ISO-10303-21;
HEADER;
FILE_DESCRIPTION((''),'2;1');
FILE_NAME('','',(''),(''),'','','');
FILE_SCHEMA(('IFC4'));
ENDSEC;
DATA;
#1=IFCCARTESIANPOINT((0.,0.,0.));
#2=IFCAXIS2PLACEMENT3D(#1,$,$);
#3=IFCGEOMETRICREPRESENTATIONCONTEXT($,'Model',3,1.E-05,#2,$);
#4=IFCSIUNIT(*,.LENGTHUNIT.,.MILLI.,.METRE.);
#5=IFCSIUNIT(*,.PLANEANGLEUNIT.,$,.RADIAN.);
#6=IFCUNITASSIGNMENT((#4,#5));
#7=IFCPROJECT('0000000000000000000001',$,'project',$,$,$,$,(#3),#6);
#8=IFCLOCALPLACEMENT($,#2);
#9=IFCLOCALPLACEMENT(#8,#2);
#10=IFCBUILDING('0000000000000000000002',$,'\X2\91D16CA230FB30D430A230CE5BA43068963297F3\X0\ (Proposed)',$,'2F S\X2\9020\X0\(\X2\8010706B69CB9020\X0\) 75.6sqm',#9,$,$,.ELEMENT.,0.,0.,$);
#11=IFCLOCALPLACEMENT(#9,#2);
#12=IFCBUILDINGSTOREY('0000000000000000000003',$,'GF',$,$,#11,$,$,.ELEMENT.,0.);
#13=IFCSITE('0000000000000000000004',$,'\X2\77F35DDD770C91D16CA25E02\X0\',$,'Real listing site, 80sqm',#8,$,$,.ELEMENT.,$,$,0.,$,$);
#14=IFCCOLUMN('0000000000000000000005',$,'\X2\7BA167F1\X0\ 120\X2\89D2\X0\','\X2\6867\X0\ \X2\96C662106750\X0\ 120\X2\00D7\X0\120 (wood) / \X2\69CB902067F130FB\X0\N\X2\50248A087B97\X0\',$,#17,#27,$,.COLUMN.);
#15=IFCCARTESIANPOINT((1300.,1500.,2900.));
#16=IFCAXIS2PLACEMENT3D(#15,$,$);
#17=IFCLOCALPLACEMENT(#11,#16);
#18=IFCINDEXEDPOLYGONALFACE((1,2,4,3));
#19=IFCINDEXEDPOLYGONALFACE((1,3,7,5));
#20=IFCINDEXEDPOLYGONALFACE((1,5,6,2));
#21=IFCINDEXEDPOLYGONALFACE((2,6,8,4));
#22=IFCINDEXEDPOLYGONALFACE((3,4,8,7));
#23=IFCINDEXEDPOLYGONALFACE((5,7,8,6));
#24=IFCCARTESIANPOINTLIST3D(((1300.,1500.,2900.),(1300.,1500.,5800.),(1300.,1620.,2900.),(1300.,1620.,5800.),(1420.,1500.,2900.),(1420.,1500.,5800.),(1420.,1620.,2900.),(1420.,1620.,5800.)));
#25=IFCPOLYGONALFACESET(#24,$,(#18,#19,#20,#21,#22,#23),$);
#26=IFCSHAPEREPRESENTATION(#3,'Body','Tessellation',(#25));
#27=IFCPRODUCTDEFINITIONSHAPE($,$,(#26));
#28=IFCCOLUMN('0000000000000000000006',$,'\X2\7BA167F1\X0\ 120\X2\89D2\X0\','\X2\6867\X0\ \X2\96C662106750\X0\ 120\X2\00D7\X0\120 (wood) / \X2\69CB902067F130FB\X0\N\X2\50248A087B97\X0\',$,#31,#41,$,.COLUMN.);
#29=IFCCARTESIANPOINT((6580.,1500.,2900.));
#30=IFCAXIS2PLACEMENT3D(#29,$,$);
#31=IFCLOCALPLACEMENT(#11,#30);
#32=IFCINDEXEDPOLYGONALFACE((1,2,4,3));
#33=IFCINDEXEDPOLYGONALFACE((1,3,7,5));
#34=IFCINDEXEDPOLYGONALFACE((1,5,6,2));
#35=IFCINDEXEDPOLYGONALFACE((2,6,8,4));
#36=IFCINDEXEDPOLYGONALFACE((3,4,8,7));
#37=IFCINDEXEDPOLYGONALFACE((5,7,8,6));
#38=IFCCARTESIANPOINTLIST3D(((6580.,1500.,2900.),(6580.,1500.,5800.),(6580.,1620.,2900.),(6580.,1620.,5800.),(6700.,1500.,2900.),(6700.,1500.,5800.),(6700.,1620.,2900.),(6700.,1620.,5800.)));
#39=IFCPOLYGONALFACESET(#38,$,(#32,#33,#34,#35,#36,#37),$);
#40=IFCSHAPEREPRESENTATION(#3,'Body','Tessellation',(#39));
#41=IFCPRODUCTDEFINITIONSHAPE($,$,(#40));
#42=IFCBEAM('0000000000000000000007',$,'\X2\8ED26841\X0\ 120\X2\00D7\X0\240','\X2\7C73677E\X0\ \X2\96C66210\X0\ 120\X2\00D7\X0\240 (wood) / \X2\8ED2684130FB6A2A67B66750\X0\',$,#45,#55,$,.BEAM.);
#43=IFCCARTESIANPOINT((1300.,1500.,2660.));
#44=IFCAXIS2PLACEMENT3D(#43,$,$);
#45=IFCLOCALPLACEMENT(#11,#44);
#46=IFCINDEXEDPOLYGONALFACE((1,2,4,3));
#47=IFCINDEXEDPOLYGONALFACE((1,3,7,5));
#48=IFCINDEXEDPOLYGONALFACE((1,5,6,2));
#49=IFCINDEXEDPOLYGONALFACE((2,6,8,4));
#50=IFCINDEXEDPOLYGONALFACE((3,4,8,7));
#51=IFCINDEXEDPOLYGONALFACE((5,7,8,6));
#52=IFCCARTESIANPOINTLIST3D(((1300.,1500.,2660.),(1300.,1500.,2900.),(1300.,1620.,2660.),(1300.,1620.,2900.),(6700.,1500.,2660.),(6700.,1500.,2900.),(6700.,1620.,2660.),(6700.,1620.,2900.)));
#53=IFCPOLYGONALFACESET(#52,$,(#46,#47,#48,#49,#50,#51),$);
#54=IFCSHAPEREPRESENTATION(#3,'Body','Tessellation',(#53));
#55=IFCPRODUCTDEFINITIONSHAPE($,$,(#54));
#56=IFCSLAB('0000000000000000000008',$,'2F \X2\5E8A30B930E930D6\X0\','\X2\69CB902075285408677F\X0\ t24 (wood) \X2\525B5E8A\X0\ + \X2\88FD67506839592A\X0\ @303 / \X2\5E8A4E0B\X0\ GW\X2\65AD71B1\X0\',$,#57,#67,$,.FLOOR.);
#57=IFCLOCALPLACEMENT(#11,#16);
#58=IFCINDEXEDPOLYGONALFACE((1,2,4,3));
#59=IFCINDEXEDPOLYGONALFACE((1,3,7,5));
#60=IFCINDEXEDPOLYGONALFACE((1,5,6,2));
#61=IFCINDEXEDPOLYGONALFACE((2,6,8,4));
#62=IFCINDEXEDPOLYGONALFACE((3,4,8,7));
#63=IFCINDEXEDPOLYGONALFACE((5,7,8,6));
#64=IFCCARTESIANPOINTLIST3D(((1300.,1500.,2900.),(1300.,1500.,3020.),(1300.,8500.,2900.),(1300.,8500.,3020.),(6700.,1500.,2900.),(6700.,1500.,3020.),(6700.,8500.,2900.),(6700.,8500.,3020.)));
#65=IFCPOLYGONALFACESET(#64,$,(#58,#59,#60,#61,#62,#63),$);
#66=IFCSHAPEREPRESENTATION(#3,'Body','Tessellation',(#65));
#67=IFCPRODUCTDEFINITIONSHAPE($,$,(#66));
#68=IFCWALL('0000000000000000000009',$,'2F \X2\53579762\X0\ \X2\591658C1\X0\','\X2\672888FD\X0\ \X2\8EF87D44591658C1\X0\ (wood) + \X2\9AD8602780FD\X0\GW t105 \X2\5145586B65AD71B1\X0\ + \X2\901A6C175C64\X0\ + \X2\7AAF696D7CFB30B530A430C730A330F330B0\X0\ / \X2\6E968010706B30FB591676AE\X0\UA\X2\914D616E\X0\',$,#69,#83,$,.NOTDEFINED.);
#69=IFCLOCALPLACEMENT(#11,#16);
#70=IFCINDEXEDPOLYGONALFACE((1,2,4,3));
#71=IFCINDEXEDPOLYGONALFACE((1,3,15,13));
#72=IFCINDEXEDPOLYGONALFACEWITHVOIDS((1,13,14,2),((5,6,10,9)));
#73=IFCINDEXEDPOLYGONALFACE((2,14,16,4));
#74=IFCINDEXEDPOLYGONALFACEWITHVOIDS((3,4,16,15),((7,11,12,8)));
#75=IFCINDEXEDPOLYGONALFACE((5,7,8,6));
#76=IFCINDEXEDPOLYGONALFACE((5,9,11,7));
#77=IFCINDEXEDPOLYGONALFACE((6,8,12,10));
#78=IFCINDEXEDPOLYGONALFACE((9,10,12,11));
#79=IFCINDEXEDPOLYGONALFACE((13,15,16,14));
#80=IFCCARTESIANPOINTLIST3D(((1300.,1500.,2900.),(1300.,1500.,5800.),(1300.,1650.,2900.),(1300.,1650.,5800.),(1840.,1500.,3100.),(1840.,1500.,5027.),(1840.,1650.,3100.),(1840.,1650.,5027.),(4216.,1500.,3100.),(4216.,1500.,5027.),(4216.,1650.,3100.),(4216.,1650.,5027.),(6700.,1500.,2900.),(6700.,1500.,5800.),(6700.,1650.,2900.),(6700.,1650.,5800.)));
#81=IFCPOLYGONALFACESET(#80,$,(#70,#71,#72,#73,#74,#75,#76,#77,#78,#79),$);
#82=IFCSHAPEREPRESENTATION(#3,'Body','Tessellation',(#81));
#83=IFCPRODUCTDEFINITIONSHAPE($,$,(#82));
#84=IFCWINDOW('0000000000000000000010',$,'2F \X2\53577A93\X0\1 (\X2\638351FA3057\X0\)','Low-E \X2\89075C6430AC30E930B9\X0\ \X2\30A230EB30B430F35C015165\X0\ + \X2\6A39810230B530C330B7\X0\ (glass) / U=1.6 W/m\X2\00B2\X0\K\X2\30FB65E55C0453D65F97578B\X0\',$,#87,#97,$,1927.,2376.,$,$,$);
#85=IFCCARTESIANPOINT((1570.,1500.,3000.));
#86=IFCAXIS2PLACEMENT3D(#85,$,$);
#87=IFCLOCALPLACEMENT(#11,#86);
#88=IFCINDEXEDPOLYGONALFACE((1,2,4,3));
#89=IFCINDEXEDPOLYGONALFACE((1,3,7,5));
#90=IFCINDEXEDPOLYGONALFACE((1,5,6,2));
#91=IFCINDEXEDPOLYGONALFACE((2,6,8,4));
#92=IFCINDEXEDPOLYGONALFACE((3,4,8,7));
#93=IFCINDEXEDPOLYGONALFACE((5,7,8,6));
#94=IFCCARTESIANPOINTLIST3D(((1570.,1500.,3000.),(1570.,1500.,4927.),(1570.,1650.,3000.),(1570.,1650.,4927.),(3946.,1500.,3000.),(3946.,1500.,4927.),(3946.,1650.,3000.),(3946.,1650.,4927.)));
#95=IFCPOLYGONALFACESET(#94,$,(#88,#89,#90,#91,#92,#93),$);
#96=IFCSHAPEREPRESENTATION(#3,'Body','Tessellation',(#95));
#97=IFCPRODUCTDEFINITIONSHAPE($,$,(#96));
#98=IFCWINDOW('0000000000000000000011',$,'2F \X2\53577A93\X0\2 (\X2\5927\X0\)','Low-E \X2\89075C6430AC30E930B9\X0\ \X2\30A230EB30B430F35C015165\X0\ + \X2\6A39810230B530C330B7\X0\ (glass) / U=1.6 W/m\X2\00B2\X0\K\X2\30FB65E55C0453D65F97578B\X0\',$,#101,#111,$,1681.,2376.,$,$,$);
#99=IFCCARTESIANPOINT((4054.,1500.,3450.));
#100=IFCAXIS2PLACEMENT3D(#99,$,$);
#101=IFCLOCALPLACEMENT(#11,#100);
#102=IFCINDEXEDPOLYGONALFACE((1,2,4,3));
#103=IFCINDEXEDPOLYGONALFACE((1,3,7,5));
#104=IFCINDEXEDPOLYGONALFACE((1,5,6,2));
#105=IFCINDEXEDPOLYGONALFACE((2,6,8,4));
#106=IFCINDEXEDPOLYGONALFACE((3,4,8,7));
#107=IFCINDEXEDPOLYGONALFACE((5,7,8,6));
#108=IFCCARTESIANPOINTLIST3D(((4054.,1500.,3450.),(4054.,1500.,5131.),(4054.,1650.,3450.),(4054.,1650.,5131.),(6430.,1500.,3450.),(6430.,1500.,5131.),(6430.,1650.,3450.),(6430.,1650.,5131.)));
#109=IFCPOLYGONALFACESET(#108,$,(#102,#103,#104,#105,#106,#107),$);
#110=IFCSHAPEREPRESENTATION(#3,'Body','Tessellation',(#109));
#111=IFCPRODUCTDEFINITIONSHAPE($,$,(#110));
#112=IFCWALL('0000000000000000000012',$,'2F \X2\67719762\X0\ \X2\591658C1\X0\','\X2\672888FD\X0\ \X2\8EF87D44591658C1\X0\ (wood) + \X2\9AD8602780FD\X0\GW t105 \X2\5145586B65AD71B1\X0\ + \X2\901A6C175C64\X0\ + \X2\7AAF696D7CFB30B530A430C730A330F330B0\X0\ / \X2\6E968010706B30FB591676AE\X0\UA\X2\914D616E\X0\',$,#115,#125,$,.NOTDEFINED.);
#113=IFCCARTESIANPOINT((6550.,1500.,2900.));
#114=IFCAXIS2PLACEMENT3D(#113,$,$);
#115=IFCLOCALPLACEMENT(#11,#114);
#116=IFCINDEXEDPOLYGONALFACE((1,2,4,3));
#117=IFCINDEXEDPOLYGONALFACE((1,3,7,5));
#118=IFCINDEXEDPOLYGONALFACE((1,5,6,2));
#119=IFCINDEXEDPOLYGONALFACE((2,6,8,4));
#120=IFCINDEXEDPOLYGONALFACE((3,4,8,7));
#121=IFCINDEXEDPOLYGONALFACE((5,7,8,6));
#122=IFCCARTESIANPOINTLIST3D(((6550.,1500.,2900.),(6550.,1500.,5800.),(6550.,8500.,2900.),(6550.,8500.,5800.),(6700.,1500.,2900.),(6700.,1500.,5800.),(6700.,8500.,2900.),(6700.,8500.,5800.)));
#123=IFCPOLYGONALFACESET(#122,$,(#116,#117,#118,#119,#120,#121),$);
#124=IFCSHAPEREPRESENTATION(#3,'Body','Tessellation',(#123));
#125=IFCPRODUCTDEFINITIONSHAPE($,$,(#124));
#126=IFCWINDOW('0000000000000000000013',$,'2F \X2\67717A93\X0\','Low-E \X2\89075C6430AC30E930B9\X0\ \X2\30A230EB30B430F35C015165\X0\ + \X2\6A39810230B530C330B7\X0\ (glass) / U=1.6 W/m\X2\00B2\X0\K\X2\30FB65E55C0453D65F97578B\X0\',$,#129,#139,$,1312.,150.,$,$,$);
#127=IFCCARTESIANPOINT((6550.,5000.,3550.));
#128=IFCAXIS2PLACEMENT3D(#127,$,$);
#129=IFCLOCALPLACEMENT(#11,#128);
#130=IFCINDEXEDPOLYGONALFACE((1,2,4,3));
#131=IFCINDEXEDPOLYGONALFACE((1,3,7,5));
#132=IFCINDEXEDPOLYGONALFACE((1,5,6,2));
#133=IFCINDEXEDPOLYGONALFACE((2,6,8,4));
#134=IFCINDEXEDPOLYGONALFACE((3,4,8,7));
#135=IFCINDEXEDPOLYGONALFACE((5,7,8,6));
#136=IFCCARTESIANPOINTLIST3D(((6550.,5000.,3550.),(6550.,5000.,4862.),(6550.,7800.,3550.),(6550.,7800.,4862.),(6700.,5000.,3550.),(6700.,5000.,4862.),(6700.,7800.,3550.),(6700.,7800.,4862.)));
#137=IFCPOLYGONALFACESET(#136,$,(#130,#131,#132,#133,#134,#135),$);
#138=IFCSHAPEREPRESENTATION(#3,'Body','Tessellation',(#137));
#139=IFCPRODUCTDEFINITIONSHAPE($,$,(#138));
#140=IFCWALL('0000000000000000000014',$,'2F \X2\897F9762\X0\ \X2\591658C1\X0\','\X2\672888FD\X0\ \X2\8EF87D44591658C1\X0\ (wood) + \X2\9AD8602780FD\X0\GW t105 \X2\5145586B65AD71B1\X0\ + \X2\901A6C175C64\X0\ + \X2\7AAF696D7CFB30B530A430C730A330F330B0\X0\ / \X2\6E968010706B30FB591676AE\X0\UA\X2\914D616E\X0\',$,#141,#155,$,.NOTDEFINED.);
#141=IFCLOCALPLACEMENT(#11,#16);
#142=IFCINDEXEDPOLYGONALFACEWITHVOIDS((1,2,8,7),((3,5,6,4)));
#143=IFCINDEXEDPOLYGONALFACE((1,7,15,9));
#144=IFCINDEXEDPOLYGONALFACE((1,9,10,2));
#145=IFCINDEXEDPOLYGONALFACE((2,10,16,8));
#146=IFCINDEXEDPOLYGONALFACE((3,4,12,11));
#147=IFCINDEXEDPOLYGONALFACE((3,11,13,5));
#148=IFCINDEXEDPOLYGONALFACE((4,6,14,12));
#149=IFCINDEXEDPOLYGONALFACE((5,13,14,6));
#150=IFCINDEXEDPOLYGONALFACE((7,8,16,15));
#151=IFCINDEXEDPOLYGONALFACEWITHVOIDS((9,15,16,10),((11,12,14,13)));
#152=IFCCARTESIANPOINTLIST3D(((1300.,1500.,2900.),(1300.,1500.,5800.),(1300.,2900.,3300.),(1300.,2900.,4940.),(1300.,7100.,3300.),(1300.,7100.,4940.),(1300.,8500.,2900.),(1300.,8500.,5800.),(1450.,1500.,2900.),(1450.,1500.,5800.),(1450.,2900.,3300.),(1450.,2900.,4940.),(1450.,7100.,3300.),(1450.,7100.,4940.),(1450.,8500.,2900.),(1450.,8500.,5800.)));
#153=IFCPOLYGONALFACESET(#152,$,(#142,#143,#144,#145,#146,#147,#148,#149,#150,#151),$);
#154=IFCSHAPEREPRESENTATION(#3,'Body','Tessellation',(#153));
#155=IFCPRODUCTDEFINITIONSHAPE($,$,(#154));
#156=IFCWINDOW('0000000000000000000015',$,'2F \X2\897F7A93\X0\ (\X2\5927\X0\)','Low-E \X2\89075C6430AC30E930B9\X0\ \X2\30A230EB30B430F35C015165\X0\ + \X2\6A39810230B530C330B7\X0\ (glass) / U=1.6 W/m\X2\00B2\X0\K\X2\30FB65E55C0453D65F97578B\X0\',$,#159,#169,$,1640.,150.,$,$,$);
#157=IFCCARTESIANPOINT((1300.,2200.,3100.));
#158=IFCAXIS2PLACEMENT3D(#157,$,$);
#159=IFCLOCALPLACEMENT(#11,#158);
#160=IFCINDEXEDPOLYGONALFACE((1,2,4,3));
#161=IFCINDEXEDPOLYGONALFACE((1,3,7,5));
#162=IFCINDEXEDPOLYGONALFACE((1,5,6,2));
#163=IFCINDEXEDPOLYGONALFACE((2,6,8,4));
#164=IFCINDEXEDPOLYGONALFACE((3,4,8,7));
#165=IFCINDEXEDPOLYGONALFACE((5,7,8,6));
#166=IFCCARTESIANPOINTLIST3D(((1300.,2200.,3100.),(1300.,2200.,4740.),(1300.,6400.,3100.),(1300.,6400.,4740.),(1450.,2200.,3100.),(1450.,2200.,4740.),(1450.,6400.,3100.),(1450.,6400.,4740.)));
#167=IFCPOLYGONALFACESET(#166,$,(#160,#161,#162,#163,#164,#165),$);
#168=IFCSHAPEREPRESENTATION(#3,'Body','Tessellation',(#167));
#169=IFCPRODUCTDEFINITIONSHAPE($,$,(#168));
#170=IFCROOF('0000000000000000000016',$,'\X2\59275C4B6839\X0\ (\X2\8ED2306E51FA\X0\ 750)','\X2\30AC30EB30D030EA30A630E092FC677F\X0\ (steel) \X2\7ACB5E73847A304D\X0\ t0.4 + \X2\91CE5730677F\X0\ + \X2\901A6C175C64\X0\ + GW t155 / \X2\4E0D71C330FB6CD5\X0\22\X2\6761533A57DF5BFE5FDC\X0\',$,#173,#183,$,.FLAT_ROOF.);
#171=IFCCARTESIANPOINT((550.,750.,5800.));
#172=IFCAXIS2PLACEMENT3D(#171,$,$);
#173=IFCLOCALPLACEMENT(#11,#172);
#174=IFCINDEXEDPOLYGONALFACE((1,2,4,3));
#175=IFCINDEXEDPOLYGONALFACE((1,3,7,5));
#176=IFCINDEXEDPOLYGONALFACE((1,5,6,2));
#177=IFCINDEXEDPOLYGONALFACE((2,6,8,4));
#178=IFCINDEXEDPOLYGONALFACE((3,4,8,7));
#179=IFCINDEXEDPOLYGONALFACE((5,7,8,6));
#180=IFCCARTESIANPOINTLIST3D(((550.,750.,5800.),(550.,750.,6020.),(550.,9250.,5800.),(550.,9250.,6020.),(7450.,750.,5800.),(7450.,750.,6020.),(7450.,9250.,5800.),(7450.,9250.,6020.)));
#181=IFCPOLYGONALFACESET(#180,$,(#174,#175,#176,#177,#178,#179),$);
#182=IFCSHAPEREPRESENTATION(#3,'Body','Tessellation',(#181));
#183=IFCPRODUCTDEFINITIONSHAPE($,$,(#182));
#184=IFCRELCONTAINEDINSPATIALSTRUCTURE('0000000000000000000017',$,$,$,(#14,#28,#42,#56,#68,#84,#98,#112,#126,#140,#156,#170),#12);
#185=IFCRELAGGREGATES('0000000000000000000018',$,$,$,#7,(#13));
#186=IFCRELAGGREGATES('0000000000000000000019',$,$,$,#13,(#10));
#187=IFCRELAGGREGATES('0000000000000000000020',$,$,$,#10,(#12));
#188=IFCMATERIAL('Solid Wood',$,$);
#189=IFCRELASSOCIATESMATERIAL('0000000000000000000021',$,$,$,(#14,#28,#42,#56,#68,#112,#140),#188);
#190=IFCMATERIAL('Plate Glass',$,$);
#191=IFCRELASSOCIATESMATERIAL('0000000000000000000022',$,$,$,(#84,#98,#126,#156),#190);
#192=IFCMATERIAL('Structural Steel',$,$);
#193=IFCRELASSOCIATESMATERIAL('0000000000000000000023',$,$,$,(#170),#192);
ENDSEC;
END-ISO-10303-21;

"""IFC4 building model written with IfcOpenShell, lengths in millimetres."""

from ifc_helpers import new_model, si_unit, frame, frame_2d, origin, place, context, project, spatial, rectangle, extrude, material, element, fill, save


model = new_model("IFC4")

# Units and contexts
model_context = context("Model", 3, precision=1e-05, world=origin())
ifc_project = project(units=[si_unit("LENGTHUNIT", "METRE", prefix="MILLI"), si_unit("PLANEANGLEUNIT", "RADIAN")], contexts=[model_context])

# Site, building, storey
site_placement = place(None, origin())
site = spatial("IfcSite", under=ifc_project, at=site_placement, Name="石川県金沢市", ObjectType="Real listing site, 80sqm", CompositionType="ELEMENT", RefElevation=0.0)
building_placement = place(site_placement, origin())
building = spatial("IfcBuilding", under=site, at=building_placement, Name="金沢・ピアノ室と防音 (Proposed)", ObjectType="2F S造(耐火構造) 75.6sqm", CompositionType="ELEMENT", ElevationOfRefHeight=0.0, ElevationOfTerrain=0.0)
storey_placement = place(building_placement, origin())
storey = spatial("IfcBuildingStorey", under=building, at=storey_placement, Name="GF", CompositionType="ELEMENT", Elevation=0.0)

# Columns
ifc_material_1 = material(Name="Solid Wood")
column_1_placement = place(storey_placement, frame((1300.0, 1500.0, 2900.0)))
element("IfcColumn", 1, at=column_1_placement, inside=storey, material=ifc_material_1, Name="管柱 120角", Description="桧 集成材 120×120 (wood) / 構造柱・N値計算", PredefinedType="COLUMN", context=model_context, shape_type="SweptSolid", body=[
    extrude(rectangle(XDim=120.0, YDim=120.0, at=frame_2d((60.0, 60.0))), frame((1300.0, 1500.0, 2900.0)), (0.0, 0.0, 1.0), 2900.0),
])
column_2_placement = place(storey_placement, frame((6580.0, 1500.0, 2900.0)))
element("IfcColumn", 2, at=column_2_placement, inside=storey, material=ifc_material_1, Name="管柱 120角", Description="桧 集成材 120×120 (wood) / 構造柱・N値計算", PredefinedType="COLUMN", context=model_context, shape_type="SweptSolid", body=[
    extrude(rectangle(XDim=120.0, YDim=120.0, at=frame_2d((60.0, 60.0))), frame((6580.0, 1500.0, 2900.0)), (0.0, 0.0, 1.0), 2900.0),
])

# Beam
beam_1_placement = place(storey_placement, frame((1300.0, 1500.0, 2660.0)))
element("IfcBeam", 3, at=beam_1_placement, inside=storey, material=ifc_material_1, Name="軒桁 120×240", Description="米松 集成 120×240 (wood) / 軒桁・横架材", PredefinedType="BEAM", context=model_context, shape_type="SweptSolid", body=[
    extrude(rectangle(XDim=5400.0, YDim=120.0, at=frame_2d((2700.0, 60.0))), frame((1300.0, 1500.0, 2660.0)), (0.0, 0.0, 1.0), 240.0),
])

# Slab
slab_placement = place(storey_placement, frame((1300.0, 1500.0, 2900.0)))
element("IfcSlab", 4, at=slab_placement, inside=storey, material=ifc_material_1, Name="2F 床スラブ", Description="構造用合板 t24 (wood) 剛床 + 製材根太 @303 / 床下 GW断熱", PredefinedType="FLOOR", context=model_context, shape_type="SweptSolid", body=[
    extrude(rectangle(XDim=5400.0, YDim=7000.0, at=frame_2d((2700.0, 3500.0))), frame((1300.0, 1500.0, 2900.0)), (0.0, 0.0, 1.0), 120.0),
])

# Wall, openings, windows
wall_1_placement = place(storey_placement, frame((1300.0, 1500.0, 2900.0)))
wall_1 = element("IfcWall", 5, at=wall_1_placement, inside=storey, material=ifc_material_1, Name="2F 南面 外壁", Description="木製 軸組外壁 (wood) + 高性能GW t105 充填断熱 + 通気層 + 窯業系サイディング / 準耐火・外皮UA配慮", PredefinedType="NOTDEFINED", context=model_context, shape_type="SweptSolid", body=[
    extrude(rectangle(XDim=5400.0, YDim=150.0, at=frame_2d((2700.0, 75.0))), frame((1300.0, 1500.0, 2900.0)), (0.0, 0.0, 1.0), 2900.0),
])
opening_1_placement = place(storey_placement, frame((1570.0, 1500.0, 3000.0)))
opening_1 = element("IfcOpeningElement", 6, at=opening_1_placement, cuts=wall_1, PredefinedType="NOTDEFINED", context=model_context, shape_type="SweptSolid", body=[
    extrude(rectangle(XDim=2376.0, YDim=150.0, at=frame_2d((1188.0, 75.0))), frame((1570.0, 1500.0, 3000.0)), (0.0, 0.0, 1.0), 1927.0),
])
opening_2_placement = place(storey_placement, frame((4054.0, 1500.0, 3450.0)))
opening_2 = element("IfcOpeningElement", 7, at=opening_2_placement, cuts=wall_1, PredefinedType="NOTDEFINED", context=model_context, shape_type="SweptSolid", body=[
    extrude(rectangle(XDim=2376.0, YDim=150.0, at=frame_2d((1188.0, 75.0))), frame((4054.0, 1500.0, 3450.0)), (0.0, 0.0, 1.0), 1681.0),
])
ifc_material_2 = material(Name="Plate Glass")
window_1_placement = place(storey_placement, frame((1570.0, 1500.0, 3000.0)))
window_1 = element("IfcWindow", 8, at=window_1_placement, inside=storey, material=ifc_material_2, Name="2F 南窓1 (掃出し)", Description="Low-E 複層ガラス アルゴン封入 + 樹脂サッシ (glass) / U=1.6 W/m²K・日射取得型", OverallHeight=1927.0, OverallWidth=2376.0, context=model_context, shape_type="SweptSolid", body=[
    extrude(rectangle(XDim=2376.0, YDim=150.0, at=frame_2d((1188.0, 75.0))), frame((1570.0, 1500.0, 3000.0)), (0.0, 0.0, 1.0), 1927.0),
])
fill(opening_1, window_1)
window_2_placement = place(storey_placement, frame((4054.0, 1500.0, 3450.0)))
window_2 = element("IfcWindow", 9, at=window_2_placement, inside=storey, material=ifc_material_2, Name="2F 南窓2 (大)", Description="Low-E 複層ガラス アルゴン封入 + 樹脂サッシ (glass) / U=1.6 W/m²K・日射取得型", OverallHeight=1681.0, OverallWidth=2376.0, context=model_context, shape_type="SweptSolid", body=[
    extrude(rectangle(XDim=2376.0, YDim=150.0, at=frame_2d((1188.0, 75.0))), frame((4054.0, 1500.0, 3450.0)), (0.0, 0.0, 1.0), 1681.0),
])
fill(opening_2, window_2)

# Walls, openings, windows
wall_2_placement = place(storey_placement, frame((6550.0, 1500.0, 2900.0)))
wall_2 = element("IfcWall", 10, at=wall_2_placement, inside=storey, material=ifc_material_1, Name="2F 東面 外壁", Description="木製 軸組外壁 (wood) + 高性能GW t105 充填断熱 + 通気層 + 窯業系サイディング / 準耐火・外皮UA配慮", PredefinedType="NOTDEFINED", context=model_context, shape_type="SweptSolid", body=[
    extrude(rectangle(XDim=150.0, YDim=7000.0, at=frame_2d((75.0, 3500.0))), frame((6550.0, 1500.0, 2900.0)), (0.0, 0.0, 1.0), 2900.0),
])
opening_3_placement = place(storey_placement, frame((6550.0, 5000.0, 3550.0)))
opening_3 = element("IfcOpeningElement", 11, at=opening_3_placement, cuts=wall_2, PredefinedType="NOTDEFINED", context=model_context, shape_type="SweptSolid", body=[
    extrude(rectangle(XDim=150.0, YDim=2800.0, at=frame_2d((75.0, 1400.0))), frame((6550.0, 5000.0, 3550.0)), (0.0, 0.0, 1.0), 1312.0),
])
window_3_placement = place(storey_placement, frame((6550.0, 5000.0, 3550.0)))
window_3 = element("IfcWindow", 12, at=window_3_placement, inside=storey, material=ifc_material_2, Name="2F 東窓", Description="Low-E 複層ガラス アルゴン封入 + 樹脂サッシ (glass) / U=1.6 W/m²K・日射取得型", OverallHeight=1312.0, OverallWidth=150.0, context=model_context, shape_type="SweptSolid", body=[
    extrude(rectangle(XDim=150.0, YDim=2800.0, at=frame_2d((75.0, 1400.0))), frame((6550.0, 5000.0, 3550.0)), (0.0, 0.0, 1.0), 1312.0),
])
fill(opening_3, window_3)
wall_3_placement = place(storey_placement, frame((1300.0, 1500.0, 2900.0)))
wall_3 = element("IfcWall", 13, at=wall_3_placement, inside=storey, material=ifc_material_1, Name="2F 西面 外壁", Description="木製 軸組外壁 (wood) + 高性能GW t105 充填断熱 + 通気層 + 窯業系サイディング / 準耐火・外皮UA配慮", PredefinedType="NOTDEFINED", context=model_context, shape_type="SweptSolid", body=[
    extrude(rectangle(XDim=150.0, YDim=7000.0, at=frame_2d((75.0, 3500.0))), frame((1300.0, 1500.0, 2900.0)), (0.0, 0.0, 1.0), 2900.0),
])
opening_4_placement = place(storey_placement, frame((1300.0, 2200.0, 3100.0)))
opening_4 = element("IfcOpeningElement", 14, at=opening_4_placement, cuts=wall_3, PredefinedType="NOTDEFINED", context=model_context, shape_type="SweptSolid", body=[
    extrude(rectangle(XDim=150.0, YDim=4200.0, at=frame_2d((75.0, 2100.0))), frame((1300.0, 2200.0, 3100.0)), (0.0, 0.0, 1.0), 1640.0),
])
window_4_placement = place(storey_placement, frame((1300.0, 2200.0, 3100.0)))
window_4 = element("IfcWindow", 15, at=window_4_placement, inside=storey, material=ifc_material_2, Name="2F 西窓 (大)", Description="Low-E 複層ガラス アルゴン封入 + 樹脂サッシ (glass) / U=1.6 W/m²K・日射取得型", OverallHeight=1640.0, OverallWidth=150.0, context=model_context, shape_type="SweptSolid", body=[
    extrude(rectangle(XDim=150.0, YDim=4200.0, at=frame_2d((75.0, 2100.0))), frame((1300.0, 2200.0, 3100.0)), (0.0, 0.0, 1.0), 1640.0),
])
fill(opening_4, window_4)

# Roof
ifc_material_3 = material(Name="Structural Steel")
roof_placement = place(storey_placement, frame((550.0, 750.0, 5800.0)))
element("IfcRoof", 16, at=roof_placement, inside=storey, material=ifc_material_3, Name="大屋根 (軒の出 750)", Description="ガルバリウム鋼板 (steel) 立平葺き t0.4 + 野地板 + 通気層 + GW t155 / 不燃・法22条区域対応", PredefinedType="FLAT_ROOF", context=model_context, shape_type="SweptSolid", body=[
    extrude(rectangle(XDim=6900.0, YDim=8500.0, at=frame_2d((3450.0, 4250.0))), frame((550.0, 750.0, 5800.0)), (0.0, 0.0, 1.0), 220.0),
])

save(model, "model.ifc")
